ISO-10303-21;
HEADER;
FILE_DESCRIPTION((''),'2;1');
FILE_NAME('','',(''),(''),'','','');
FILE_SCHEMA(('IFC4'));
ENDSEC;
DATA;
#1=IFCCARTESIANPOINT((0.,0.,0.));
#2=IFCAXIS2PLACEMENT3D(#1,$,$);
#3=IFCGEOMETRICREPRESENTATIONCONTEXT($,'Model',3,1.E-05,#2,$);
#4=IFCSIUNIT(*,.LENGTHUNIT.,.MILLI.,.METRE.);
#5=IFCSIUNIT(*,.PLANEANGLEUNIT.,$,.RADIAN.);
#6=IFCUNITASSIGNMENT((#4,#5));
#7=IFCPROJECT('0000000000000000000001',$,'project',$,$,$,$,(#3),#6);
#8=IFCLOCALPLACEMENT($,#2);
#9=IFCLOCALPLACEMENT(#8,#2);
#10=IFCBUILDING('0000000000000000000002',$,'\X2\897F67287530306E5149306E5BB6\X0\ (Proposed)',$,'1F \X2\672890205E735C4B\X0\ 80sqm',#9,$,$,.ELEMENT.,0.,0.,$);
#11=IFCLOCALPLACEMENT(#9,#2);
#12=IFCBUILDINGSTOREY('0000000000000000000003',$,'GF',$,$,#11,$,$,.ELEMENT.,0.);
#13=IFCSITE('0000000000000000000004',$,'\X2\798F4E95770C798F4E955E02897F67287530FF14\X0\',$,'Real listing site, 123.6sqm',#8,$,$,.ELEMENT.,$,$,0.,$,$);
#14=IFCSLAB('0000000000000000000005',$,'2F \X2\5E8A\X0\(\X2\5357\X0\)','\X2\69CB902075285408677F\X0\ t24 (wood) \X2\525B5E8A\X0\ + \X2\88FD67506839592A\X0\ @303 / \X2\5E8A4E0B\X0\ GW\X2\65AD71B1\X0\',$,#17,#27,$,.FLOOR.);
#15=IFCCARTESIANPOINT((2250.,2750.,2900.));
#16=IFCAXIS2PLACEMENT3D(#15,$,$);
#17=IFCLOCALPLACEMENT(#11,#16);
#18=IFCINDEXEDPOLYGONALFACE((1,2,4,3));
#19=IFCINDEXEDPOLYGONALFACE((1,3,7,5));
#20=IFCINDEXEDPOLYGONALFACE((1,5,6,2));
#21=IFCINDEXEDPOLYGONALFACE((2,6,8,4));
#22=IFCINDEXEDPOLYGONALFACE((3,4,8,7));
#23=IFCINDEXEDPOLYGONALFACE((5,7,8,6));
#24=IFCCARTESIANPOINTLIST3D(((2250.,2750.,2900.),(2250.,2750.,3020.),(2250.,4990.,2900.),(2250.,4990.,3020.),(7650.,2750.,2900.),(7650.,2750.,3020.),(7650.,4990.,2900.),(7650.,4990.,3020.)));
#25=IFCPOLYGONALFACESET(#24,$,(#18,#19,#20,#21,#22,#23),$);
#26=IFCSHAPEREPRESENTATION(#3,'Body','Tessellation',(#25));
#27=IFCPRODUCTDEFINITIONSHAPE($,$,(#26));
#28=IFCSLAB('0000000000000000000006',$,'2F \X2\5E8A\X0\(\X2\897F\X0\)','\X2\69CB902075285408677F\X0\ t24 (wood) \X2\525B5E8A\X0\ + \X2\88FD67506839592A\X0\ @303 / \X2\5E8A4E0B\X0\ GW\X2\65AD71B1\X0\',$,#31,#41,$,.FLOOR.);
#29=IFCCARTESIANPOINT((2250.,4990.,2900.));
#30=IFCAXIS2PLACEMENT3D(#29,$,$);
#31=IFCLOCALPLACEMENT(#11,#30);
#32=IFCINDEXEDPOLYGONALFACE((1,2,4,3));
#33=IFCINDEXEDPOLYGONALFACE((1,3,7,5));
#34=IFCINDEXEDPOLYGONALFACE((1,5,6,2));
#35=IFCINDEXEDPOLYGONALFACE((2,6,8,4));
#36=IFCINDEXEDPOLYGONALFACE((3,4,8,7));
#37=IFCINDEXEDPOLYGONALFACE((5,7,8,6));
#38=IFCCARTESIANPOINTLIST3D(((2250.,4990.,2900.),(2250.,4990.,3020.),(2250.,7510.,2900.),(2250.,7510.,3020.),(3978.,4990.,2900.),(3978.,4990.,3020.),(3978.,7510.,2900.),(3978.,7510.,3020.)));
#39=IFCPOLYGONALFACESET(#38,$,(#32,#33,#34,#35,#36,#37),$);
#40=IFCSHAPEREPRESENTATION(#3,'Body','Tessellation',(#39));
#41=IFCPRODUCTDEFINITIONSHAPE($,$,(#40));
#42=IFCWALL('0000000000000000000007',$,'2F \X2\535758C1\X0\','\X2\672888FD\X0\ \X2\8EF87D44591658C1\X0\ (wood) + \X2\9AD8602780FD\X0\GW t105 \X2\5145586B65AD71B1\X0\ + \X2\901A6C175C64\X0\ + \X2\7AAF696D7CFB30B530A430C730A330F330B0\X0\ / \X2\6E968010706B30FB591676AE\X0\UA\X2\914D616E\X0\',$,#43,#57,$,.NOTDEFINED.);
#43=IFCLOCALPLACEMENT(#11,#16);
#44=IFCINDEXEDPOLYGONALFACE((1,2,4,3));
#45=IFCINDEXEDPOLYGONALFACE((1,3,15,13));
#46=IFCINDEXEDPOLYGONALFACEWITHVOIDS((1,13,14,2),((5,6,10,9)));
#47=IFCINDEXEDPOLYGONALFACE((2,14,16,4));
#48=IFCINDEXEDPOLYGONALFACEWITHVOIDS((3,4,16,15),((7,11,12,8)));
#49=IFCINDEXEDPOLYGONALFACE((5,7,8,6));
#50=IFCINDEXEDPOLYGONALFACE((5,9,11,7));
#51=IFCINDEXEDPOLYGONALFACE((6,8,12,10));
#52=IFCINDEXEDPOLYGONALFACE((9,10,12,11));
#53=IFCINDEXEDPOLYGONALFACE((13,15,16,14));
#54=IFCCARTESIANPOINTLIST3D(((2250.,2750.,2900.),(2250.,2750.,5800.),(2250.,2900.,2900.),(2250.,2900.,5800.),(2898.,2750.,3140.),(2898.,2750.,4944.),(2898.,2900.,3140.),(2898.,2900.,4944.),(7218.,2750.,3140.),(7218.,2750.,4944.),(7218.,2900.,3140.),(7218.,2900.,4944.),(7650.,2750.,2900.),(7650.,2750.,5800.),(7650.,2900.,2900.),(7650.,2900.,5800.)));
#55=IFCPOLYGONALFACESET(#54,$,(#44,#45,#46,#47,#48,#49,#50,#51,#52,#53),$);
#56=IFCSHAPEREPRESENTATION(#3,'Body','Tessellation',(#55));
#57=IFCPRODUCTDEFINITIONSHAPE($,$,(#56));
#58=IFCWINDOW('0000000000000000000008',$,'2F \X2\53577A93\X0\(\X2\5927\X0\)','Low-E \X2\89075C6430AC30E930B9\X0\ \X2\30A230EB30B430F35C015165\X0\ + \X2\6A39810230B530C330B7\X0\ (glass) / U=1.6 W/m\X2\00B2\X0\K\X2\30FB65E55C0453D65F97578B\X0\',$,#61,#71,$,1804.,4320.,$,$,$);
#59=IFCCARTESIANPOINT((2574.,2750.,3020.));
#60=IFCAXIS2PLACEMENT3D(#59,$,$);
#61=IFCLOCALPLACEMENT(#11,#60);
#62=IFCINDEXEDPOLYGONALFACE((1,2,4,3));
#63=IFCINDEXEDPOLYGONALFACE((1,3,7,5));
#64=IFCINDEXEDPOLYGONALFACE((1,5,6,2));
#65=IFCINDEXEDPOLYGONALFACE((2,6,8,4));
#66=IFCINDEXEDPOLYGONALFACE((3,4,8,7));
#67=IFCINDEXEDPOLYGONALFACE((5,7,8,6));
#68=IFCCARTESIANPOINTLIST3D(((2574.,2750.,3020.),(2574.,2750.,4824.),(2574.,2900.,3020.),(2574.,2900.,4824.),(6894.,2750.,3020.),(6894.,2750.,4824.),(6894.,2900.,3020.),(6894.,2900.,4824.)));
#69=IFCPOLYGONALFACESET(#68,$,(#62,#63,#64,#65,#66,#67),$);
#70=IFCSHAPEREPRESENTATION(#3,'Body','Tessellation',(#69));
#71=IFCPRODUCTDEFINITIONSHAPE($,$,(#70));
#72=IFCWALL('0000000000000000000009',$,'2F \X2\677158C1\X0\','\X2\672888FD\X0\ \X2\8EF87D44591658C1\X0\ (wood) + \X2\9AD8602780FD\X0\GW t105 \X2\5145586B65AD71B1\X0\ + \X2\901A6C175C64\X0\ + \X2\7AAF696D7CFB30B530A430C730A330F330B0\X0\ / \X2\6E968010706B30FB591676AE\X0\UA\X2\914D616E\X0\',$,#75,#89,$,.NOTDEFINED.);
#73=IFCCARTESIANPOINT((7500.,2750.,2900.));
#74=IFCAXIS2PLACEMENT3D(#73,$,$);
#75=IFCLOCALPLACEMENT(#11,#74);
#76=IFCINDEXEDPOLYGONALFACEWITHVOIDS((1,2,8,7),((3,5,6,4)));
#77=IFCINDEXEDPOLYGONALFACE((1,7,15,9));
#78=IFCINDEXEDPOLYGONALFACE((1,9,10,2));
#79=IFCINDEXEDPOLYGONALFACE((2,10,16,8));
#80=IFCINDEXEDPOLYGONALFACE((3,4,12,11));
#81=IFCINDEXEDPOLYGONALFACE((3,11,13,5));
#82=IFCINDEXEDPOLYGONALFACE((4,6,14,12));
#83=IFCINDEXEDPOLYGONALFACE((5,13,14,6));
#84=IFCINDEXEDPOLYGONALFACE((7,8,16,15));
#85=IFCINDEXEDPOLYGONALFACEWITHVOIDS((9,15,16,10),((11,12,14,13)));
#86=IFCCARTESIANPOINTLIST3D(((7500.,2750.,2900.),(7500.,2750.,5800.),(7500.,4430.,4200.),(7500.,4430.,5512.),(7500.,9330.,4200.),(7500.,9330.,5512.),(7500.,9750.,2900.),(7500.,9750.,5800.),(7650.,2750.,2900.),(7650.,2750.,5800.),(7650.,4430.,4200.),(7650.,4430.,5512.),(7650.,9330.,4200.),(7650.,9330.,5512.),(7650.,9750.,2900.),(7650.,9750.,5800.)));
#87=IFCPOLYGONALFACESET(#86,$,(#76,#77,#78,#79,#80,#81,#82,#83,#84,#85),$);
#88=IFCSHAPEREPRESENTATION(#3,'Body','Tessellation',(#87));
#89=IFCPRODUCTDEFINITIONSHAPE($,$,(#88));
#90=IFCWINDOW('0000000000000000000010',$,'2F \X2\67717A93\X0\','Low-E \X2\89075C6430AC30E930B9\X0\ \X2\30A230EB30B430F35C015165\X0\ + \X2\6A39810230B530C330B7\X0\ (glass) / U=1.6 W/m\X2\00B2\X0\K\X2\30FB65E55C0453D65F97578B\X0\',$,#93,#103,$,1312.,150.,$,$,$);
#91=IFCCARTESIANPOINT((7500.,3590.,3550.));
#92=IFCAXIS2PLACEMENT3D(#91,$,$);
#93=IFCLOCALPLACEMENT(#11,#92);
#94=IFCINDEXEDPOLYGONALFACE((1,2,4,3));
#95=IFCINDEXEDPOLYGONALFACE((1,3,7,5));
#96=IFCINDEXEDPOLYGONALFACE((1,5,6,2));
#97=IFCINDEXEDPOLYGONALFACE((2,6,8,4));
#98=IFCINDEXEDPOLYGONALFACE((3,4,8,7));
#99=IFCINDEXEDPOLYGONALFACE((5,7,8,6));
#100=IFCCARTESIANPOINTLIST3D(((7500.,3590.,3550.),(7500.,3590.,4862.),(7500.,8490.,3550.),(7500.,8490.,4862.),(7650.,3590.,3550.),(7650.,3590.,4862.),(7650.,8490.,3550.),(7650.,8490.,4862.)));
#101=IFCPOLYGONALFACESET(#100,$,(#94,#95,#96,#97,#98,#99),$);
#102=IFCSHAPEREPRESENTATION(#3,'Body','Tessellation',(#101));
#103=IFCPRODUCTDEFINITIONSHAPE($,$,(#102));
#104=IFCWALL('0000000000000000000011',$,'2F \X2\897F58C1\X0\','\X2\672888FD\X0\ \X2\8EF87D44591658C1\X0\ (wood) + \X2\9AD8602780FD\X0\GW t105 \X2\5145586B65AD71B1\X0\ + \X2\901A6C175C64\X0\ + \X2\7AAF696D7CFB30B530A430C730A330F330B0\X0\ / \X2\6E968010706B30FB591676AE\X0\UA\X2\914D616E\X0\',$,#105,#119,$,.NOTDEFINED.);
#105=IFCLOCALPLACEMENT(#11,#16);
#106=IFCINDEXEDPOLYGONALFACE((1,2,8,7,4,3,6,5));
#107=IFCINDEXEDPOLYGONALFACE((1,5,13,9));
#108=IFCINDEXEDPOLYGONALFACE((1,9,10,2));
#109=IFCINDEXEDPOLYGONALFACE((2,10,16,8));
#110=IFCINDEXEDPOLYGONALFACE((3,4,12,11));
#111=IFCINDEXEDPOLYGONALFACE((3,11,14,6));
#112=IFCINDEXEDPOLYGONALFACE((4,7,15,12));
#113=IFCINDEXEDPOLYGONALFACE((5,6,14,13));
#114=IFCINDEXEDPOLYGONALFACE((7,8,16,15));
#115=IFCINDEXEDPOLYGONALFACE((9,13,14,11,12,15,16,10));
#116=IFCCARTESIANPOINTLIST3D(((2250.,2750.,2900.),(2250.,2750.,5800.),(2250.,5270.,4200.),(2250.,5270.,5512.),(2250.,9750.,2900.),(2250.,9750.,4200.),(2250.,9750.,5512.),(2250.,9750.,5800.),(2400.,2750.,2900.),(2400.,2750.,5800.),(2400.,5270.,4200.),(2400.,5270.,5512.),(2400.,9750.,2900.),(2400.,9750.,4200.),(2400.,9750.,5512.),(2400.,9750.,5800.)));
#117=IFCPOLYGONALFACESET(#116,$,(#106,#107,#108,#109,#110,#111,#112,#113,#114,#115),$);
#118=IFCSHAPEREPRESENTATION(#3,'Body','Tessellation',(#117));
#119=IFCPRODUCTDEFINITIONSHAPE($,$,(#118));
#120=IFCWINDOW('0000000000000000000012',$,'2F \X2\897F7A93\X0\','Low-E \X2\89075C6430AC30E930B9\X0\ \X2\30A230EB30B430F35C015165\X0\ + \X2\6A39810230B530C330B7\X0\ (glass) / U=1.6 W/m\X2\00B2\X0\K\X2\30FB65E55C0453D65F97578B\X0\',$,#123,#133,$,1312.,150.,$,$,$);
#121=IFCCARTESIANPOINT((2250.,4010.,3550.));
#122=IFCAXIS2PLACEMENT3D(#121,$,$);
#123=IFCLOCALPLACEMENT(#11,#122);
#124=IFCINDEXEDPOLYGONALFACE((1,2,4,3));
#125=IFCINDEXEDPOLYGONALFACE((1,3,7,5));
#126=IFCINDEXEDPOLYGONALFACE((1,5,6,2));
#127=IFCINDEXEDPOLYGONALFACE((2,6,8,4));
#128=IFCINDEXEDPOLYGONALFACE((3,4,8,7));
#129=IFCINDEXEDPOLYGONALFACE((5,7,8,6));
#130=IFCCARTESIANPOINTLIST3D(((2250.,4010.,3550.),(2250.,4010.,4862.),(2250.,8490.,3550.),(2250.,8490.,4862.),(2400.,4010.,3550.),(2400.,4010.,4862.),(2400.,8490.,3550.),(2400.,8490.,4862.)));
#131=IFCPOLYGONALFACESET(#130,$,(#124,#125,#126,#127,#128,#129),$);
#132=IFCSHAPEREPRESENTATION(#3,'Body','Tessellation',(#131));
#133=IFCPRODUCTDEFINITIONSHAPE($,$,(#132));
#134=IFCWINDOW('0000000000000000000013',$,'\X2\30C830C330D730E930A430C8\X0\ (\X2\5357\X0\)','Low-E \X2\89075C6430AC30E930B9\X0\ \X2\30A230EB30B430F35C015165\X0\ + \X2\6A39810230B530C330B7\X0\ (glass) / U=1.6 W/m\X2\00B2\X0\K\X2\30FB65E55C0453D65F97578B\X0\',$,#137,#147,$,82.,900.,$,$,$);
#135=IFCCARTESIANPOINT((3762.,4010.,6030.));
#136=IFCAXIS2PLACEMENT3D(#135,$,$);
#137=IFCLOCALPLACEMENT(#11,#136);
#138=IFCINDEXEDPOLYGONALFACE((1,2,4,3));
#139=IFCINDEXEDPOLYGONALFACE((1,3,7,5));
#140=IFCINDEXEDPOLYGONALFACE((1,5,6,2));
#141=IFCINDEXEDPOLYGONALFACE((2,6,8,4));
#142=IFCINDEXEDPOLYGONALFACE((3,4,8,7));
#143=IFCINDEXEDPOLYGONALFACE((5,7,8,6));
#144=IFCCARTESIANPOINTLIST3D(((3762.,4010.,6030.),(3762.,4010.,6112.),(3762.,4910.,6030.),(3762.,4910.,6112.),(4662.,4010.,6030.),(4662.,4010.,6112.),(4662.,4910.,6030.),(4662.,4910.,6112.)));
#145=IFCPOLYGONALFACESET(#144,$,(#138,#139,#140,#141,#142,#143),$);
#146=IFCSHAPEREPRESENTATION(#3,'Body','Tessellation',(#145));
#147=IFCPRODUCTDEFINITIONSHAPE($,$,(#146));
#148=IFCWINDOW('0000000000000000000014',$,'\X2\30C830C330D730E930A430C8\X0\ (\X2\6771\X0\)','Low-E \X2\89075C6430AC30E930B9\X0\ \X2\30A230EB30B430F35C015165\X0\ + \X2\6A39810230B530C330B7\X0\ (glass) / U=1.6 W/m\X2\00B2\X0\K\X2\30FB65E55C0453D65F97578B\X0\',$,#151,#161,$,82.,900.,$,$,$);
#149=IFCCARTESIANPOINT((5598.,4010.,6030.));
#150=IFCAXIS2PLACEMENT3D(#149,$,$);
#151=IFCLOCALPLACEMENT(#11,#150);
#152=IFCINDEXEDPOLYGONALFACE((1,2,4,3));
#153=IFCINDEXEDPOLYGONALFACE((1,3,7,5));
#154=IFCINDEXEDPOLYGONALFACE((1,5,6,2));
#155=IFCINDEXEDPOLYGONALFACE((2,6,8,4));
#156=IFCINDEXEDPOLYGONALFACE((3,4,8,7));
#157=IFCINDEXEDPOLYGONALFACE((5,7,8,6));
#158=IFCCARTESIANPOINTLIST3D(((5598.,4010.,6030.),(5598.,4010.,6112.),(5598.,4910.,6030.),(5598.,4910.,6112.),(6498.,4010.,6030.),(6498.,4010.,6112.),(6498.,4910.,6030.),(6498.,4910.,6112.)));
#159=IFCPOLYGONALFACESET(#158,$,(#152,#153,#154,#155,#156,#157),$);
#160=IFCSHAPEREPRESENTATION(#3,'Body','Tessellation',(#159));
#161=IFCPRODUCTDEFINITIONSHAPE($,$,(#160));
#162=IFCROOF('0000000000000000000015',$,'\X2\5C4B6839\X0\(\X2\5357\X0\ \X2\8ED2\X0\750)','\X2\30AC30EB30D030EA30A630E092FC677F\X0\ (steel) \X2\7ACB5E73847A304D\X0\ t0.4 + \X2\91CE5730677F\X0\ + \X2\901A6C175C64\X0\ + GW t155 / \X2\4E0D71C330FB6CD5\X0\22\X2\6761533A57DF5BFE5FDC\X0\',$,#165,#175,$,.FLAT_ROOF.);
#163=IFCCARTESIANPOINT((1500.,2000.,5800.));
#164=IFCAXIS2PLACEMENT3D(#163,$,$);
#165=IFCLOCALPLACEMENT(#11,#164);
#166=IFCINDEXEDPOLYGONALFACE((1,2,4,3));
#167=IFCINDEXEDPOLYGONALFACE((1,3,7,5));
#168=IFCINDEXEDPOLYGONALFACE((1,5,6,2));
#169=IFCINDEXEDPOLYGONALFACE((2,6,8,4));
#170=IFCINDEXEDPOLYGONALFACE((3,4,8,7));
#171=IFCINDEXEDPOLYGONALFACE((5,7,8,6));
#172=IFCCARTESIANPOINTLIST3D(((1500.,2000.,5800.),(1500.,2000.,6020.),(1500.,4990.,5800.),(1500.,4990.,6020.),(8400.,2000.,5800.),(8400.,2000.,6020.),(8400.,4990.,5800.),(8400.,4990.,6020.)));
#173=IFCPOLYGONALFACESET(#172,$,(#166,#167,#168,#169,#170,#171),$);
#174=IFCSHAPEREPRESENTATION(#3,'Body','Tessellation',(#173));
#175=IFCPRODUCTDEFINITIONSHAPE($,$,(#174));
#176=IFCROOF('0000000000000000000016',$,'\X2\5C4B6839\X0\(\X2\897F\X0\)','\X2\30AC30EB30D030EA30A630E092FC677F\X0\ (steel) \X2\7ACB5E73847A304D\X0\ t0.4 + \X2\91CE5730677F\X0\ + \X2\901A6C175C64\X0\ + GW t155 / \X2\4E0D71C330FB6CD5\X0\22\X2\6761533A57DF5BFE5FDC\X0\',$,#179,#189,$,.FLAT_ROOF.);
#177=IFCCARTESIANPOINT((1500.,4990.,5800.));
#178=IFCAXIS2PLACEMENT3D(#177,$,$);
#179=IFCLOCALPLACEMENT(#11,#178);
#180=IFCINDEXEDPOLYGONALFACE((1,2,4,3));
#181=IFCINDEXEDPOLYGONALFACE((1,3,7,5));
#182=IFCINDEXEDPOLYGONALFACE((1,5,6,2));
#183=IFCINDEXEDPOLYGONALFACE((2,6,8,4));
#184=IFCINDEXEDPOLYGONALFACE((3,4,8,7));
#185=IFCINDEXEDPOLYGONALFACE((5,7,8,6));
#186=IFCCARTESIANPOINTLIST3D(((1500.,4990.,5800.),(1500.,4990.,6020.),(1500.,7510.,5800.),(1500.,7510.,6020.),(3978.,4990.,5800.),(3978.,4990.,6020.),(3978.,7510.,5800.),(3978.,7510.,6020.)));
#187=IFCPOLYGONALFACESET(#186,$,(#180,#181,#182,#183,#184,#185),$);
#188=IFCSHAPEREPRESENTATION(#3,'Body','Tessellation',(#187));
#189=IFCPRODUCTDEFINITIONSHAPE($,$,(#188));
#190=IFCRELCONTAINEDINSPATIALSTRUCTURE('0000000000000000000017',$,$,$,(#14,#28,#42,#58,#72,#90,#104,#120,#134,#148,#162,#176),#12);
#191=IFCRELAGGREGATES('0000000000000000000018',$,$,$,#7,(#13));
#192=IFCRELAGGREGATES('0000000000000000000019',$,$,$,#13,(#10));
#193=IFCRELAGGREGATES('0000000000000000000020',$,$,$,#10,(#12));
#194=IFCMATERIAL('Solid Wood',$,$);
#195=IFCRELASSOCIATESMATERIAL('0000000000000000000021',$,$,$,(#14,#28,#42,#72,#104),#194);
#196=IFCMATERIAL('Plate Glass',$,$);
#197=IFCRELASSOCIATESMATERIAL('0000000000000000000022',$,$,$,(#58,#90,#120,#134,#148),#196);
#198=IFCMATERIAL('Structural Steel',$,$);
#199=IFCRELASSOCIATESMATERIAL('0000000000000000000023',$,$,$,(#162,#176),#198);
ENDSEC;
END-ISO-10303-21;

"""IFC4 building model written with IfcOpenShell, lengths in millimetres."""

from ifc_helpers import new_model, si_unit, frame, frame_2d, origin, place, context, project, spatial, rectangle, extrude, material, element, fill, save


model = new_model("IFC4")

# Units and contexts
model_context = context("Model", 3, precision=1e-05, world=origin())
ifc_project = project(units=[si_unit("LENGTHUNIT", "METRE", prefix="MILLI"), si_unit("PLANEANGLEUNIT", "RADIAN")], contexts=[model_context])

# Site, building, storey
site_placement = place(None, origin())
site = spatial("IfcSite", under=ifc_project, at=site_placement, Name="福井県福井市西木田４", ObjectType="Real listing site, 123.6sqm", CompositionType="ELEMENT", RefElevation=0.0)
building_placement = place(site_placement, origin())
building = spatial("IfcBuilding", under=site, at=building_placement, Name="西木田の光の家 (Proposed)", ObjectType="1F 木造平屋 80sqm", CompositionType="ELEMENT", ElevationOfRefHeight=0.0, ElevationOfTerrain=0.0)
storey_placement = place(building_placement, origin())
storey = spatial("IfcBuildingStorey", under=building, at=storey_placement, Name="GF", CompositionType="ELEMENT", Elevation=0.0)

# Slabs
ifc_material_1 = material(Name="Solid Wood")
slab_1_placement = place(storey_placement, frame((2250.0, 2750.0, 2900.0)))
element("IfcSlab", 1, at=slab_1_placement, inside=storey, material=ifc_material_1, Name="2F 床(南)", Description="構造用合板 t24 (wood) 剛床 + 製材根太 @303 / 床下 GW断熱", PredefinedType="FLOOR", context=model_context, shape_type="SweptSolid", body=[
    extrude(rectangle(XDim=5400.0, YDim=2240.0, at=frame_2d((2700.0, 1120.0))), frame((2250.0, 2750.0, 2900.0)), (0.0, 0.0, 1.0), 120.0),
])
slab_2_placement = place(storey_placement, frame((2250.0, 4990.0, 2900.0)))
element("IfcSlab", 2, at=slab_2_placement, inside=storey, material=ifc_material_1, Name="2F 床(西)", Description="構造用合板 t24 (wood) 剛床 + 製材根太 @303 / 床下 GW断熱", PredefinedType="FLOOR", context=model_context, shape_type="SweptSolid", body=[
    extrude(rectangle(XDim=1728.0, YDim=2520.0, at=frame_2d((864.0, 1260.0))), frame((2250.0, 4990.0, 2900.0)), (0.0, 0.0, 1.0), 120.0),
])

# Walls, openings, windows
wall_1_placement = place(storey_placement, frame((2250.0, 2750.0, 2900.0)))
wall_1 = element("IfcWall", 3, at=wall_1_placement, inside=storey, material=ifc_material_1, Name="2F 南壁", Description="木製 軸組外壁 (wood) + 高性能GW t105 充填断熱 + 通気層 + 窯業系サイディング / 準耐火・外皮UA配慮", PredefinedType="NOTDEFINED", context=model_context, shape_type="SweptSolid", body=[
    extrude(rectangle(XDim=5400.0, YDim=150.0, at=frame_2d((2700.0, 75.0))), frame((2250.0, 2750.0, 2900.0)), (0.0, 0.0, 1.0), 2900.0),
])
opening_1_placement = place(storey_placement, frame((2574.0, 2750.0, 3020.0)))
opening_1 = element("IfcOpeningElement", 4, at=opening_1_placement, cuts=wall_1, PredefinedType="NOTDEFINED", context=model_context, shape_type="SweptSolid", body=[
    extrude(rectangle(XDim=4320.0, YDim=150.0, at=frame_2d((2160.0, 75.0))), frame((2574.0, 2750.0, 3020.0)), (0.0, 0.0, 1.0), 1804.0),
])
ifc_material_2 = material(Name="Plate Glass")
window_1_placement = place(storey_placement, frame((2574.0, 2750.0, 3020.0)))
window_1 = element("IfcWindow", 5, at=window_1_placement, inside=storey, material=ifc_material_2, Name="2F 南窓(大)", Description="Low-E 複層ガラス アルゴン封入 + 樹脂サッシ (glass) / U=1.6 W/m²K・日射取得型", OverallHeight=1804.0, OverallWidth=4320.0, context=model_context, shape_type="SweptSolid", body=[
    extrude(rectangle(XDim=4320.0, YDim=150.0, at=frame_2d((2160.0, 75.0))), frame((2574.0, 2750.0, 3020.0)), (0.0, 0.0, 1.0), 1804.0),
])
fill(opening_1, window_1)
wall_2_placement = place(storey_placement, frame((7500.0, 2750.0, 2900.0)))
wall_2 = element("IfcWall", 6, at=wall_2_placement, inside=storey, material=ifc_material_1, Name="2F 東壁", Description="木製 軸組外壁 (wood) + 高性能GW t105 充填断熱 + 通気層 + 窯業系サイディング / 準耐火・外皮UA配慮", PredefinedType="NOTDEFINED", context=model_context, shape_type="SweptSolid", body=[
    extrude(rectangle(XDim=150.0, YDim=7000.0, at=frame_2d((75.0, 3500.0))), frame((7500.0, 2750.0, 2900.0)), (0.0, 0.0, 1.0), 2900.0),
])
opening_2_placement = place(storey_placement, frame((7500.0, 3590.0, 3550.0)))
opening_2 = element("IfcOpeningElement", 7, at=opening_2_placement, cuts=wall_2, PredefinedType="NOTDEFINED", context=model_context, shape_type="SweptSolid", body=[
    extrude(rectangle(XDim=150.0, YDim=4900.0, at=frame_2d((75.0, 2450.0))), frame((7500.0, 3590.0, 3550.0)), (0.0, 0.0, 1.0), 1312.0),
])
window_2_placement = place(storey_placement, frame((7500.0, 3590.0, 3550.0)))
window_2 = element("IfcWindow", 8, at=window_2_placement, inside=storey, material=ifc_material_2, Name="2F 東窓", Description="Low-E 複層ガラス アルゴン封入 + 樹脂サッシ (glass) / U=1.6 W/m²K・日射取得型", OverallHeight=1312.0, OverallWidth=150.0, context=model_context, shape_type="SweptSolid", body=[
    extrude(rectangle(XDim=150.0, YDim=4900.0, at=frame_2d((75.0, 2450.0))), frame((7500.0, 3590.0, 3550.0)), (0.0, 0.0, 1.0), 1312.0),
])
fill(opening_2, window_2)
wall_3_placement = place(storey_placement, frame((2250.0, 2750.0, 2900.0)))
wall_3 = element("IfcWall", 9, at=wall_3_placement, inside=storey, material=ifc_material_1, Name="2F 西壁", Description="木製 軸組外壁 (wood) + 高性能GW t105 充填断熱 + 通気層 + 窯業系サイディング / 準耐火・外皮UA配慮", PredefinedType="NOTDEFINED", context=model_context, shape_type="SweptSolid", body=[
    extrude(rectangle(XDim=150.0, YDim=7000.0, at=frame_2d((75.0, 3500.0))), frame((2250.0, 2750.0, 2900.0)), (0.0, 0.0, 1.0), 2900.0),
])
opening_3_placement = place(storey_placement, frame((2250.0, 4010.0, 3550.0)))
opening_3 = element("IfcOpeningElement", 10, at=opening_3_placement, cuts=wall_3, PredefinedType="NOTDEFINED", context=model_context, shape_type="SweptSolid", body=[
    extrude(rectangle(XDim=150.0, YDim=4480.0, at=frame_2d((75.0, 2240.0))), frame((2250.0, 4010.0, 3550.0)), (0.0, 0.0, 1.0), 1312.0),
])
window_3_placement = place(storey_placement, frame((2250.0, 4010.0, 3550.0)))
window_3 = element("IfcWindow", 11, at=window_3_placement, inside=storey, material=ifc_material_2, Name="2F 西窓", Description="Low-E 複層ガラス アルゴン封入 + 樹脂サッシ (glass) / U=1.6 W/m²K・日射取得型", OverallHeight=1312.0, OverallWidth=150.0, context=model_context, shape_type="SweptSolid", body=[
    extrude(rectangle(XDim=150.0, YDim=4480.0, at=frame_2d((75.0, 2240.0))), frame((2250.0, 4010.0, 3550.0)), (0.0, 0.0, 1.0), 1312.0),
])
fill(opening_3, window_3)

# Windows
window_4_placement = place(storey_placement, frame((3762.0, 4010.0, 6030.0)))
element("IfcWindow", 12, at=window_4_placement, inside=storey, material=ifc_material_2, Name="トップライト (南)", Description="Low-E 複層ガラス アルゴン封入 + 樹脂サッシ (glass) / U=1.6 W/m²K・日射取得型", OverallHeight=82.0, OverallWidth=900.0, context=model_context, shape_type="SweptSolid", body=[
    extrude(rectangle(XDim=900.0, YDim=900.0, at=frame_2d((450.0, 450.0))), frame((3762.0, 4010.0, 6030.0)), (0.0, 0.0, 1.0), 82.0),
])
window_5_placement = place(storey_placement, frame((5598.0, 4010.0, 6030.0)))
element("IfcWindow", 13, at=window_5_placement, inside=storey, material=ifc_material_2, Name="トップライト (東)", Description="Low-E 複層ガラス アルゴン封入 + 樹脂サッシ (glass) / U=1.6 W/m²K・日射取得型", OverallHeight=82.0, OverallWidth=900.0, context=model_context, shape_type="SweptSolid", body=[
    extrude(rectangle(XDim=900.0, YDim=900.0, at=frame_2d((450.0, 450.0))), frame((5598.0, 4010.0, 6030.0)), (0.0, 0.0, 1.0), 82.0),
])

# Roofs
ifc_material_3 = material(Name="Structural Steel")
roof_1_placement = place(storey_placement, frame((1500.0, 2000.0, 5800.0)))
element("IfcRoof", 14, at=roof_1_placement, inside=storey, material=ifc_material_3, Name="屋根(南 軒750)", Description="ガルバリウム鋼板 (steel) 立平葺き t0.4 + 野地板 + 通気層 + GW t155 / 不燃・法22条区域対応", PredefinedType="FLAT_ROOF", context=model_context, shape_type="SweptSolid", body=[
    extrude(rectangle(XDim=6900.0, YDim=2990.0, at=frame_2d((3450.0, 1495.0))), frame((1500.0, 2000.0, 5800.0)), (0.0, 0.0, 1.0), 220.0),
])
roof_2_placement = place(storey_placement, frame((1500.0, 4990.0, 5800.0)))
element("IfcRoof", 15, at=roof_2_placement, inside=storey, material=ifc_material_3, Name="屋根(西)", Description="ガルバリウム鋼板 (steel) 立平葺き t0.4 + 野地板 + 通気層 + GW t155 / 不燃・法22条区域対応", PredefinedType="FLAT_ROOF", context=model_context, shape_type="SweptSolid", body=[
    extrude(rectangle(XDim=2478.0, YDim=2520.0, at=frame_2d((1239.0, 1260.0))), frame((1500.0, 4990.0, 5800.0)), (0.0, 0.0, 1.0), 220.0),
])

save(model, "model.ifc")
